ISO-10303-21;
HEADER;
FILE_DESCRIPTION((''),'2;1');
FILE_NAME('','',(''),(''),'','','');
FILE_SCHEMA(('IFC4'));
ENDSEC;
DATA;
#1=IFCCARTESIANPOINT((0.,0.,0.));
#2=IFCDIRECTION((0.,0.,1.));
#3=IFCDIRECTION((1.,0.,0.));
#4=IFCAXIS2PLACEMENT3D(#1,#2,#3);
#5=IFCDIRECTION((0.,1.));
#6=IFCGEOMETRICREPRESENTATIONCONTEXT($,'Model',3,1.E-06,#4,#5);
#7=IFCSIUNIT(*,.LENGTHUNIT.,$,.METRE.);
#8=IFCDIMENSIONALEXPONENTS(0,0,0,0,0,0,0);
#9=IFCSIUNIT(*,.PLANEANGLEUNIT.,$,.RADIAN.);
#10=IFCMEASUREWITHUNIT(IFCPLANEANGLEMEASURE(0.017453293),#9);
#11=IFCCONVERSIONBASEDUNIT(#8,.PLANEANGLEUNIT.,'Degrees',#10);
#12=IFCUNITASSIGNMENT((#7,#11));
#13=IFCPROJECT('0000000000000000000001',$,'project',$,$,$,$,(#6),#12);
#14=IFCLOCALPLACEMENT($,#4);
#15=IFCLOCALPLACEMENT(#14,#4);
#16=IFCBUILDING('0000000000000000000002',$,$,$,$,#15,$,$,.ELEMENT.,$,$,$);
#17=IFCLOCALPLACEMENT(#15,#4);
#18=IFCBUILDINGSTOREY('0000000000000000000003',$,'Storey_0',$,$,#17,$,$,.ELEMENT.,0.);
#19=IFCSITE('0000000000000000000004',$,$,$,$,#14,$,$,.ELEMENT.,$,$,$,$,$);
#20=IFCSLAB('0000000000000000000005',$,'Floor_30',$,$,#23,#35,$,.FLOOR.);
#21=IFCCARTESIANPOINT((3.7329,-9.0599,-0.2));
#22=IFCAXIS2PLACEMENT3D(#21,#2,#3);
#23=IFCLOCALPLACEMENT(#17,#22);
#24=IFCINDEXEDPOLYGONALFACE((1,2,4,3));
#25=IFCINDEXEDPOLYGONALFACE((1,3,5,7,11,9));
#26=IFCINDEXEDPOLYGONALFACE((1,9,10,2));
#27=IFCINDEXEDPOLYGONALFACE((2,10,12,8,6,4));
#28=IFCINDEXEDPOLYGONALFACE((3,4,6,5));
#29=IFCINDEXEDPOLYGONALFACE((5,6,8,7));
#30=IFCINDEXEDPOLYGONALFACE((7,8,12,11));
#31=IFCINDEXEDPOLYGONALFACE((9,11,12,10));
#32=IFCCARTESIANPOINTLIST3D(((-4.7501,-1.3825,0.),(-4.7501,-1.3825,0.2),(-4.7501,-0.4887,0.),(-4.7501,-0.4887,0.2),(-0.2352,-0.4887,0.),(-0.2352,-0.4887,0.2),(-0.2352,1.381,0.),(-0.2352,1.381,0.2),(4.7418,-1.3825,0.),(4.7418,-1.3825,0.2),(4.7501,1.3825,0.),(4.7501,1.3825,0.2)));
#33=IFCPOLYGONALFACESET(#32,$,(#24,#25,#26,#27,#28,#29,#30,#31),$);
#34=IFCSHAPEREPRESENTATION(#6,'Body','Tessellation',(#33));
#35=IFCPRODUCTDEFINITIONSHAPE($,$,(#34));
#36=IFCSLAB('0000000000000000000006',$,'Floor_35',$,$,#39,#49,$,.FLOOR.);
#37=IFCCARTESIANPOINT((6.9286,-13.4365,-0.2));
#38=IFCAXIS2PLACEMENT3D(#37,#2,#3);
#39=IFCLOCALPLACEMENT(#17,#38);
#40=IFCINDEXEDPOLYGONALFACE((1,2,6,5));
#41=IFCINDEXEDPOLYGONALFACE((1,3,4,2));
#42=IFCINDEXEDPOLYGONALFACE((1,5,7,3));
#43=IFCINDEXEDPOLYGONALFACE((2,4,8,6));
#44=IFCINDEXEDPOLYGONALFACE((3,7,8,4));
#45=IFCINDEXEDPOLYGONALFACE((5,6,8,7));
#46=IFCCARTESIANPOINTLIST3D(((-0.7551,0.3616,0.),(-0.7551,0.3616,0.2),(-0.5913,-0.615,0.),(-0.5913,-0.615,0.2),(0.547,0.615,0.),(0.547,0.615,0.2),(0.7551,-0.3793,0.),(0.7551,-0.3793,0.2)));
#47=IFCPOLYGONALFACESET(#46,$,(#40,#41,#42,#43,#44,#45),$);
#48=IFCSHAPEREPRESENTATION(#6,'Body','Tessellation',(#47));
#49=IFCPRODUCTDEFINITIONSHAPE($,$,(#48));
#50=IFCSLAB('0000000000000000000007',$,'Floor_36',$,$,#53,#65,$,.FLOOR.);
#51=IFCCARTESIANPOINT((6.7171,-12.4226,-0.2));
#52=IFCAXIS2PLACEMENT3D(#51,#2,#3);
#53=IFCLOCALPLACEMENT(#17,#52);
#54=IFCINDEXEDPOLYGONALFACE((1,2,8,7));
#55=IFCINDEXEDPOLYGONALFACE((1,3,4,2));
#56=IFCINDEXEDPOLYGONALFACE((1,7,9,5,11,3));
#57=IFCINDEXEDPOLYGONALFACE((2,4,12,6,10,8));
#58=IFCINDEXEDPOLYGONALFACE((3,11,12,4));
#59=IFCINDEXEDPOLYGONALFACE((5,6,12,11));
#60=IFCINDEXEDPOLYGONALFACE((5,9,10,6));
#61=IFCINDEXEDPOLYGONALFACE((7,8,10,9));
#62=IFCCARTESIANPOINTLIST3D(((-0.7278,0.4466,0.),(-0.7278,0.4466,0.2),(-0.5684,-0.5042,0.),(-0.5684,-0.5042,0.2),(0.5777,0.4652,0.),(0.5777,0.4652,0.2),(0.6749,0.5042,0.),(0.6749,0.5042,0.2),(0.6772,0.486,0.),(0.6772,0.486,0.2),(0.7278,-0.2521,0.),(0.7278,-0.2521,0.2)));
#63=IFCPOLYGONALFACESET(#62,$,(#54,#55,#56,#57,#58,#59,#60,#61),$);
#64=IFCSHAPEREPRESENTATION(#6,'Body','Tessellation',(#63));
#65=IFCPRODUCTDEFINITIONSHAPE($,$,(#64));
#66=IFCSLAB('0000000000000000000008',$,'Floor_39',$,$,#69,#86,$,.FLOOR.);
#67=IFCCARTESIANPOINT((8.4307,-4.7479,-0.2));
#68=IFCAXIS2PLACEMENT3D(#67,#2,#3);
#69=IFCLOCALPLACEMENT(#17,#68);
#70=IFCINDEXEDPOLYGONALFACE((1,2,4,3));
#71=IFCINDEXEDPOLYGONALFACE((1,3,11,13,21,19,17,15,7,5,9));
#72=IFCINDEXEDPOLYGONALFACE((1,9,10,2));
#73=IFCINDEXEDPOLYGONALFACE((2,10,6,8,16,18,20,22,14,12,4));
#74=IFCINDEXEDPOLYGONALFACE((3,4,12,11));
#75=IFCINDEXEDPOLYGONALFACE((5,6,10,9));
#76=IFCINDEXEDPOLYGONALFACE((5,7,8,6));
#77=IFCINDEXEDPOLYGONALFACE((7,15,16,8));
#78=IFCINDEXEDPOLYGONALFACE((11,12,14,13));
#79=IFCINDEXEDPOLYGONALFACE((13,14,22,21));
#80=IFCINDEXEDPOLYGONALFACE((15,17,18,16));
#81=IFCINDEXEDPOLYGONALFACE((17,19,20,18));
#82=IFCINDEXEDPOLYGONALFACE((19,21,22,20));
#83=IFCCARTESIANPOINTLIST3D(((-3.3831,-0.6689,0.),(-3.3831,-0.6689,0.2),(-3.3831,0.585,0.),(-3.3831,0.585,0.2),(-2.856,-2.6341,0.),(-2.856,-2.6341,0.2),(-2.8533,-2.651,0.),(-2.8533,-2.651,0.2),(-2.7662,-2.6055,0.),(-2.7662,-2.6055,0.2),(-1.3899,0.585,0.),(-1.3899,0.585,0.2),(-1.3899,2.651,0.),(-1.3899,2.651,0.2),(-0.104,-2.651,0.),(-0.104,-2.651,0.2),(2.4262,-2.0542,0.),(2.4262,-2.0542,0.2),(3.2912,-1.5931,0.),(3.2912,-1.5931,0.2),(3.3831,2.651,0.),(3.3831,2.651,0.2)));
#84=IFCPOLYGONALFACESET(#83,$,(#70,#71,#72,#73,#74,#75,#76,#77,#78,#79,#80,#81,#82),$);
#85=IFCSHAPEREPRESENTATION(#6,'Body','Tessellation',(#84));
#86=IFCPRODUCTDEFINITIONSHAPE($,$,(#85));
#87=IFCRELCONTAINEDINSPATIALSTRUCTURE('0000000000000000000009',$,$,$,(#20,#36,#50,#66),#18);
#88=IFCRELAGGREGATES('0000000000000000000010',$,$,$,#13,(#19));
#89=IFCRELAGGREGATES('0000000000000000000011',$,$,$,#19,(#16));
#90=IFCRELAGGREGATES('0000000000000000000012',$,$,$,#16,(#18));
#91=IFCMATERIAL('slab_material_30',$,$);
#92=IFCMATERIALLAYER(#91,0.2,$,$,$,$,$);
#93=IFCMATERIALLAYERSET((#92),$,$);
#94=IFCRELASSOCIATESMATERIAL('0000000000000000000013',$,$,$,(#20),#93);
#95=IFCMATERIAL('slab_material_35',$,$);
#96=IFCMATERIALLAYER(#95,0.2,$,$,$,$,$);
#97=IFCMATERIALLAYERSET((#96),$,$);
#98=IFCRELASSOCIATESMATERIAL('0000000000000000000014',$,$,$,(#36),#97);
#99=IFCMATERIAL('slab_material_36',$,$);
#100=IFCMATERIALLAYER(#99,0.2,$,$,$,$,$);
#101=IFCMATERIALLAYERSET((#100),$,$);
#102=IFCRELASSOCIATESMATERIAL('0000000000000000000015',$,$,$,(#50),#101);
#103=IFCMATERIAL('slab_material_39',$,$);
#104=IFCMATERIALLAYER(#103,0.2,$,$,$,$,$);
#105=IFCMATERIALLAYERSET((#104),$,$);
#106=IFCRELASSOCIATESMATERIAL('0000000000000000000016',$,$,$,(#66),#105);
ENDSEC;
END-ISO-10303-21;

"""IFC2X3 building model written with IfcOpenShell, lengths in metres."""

from ifc_helpers import new_model, entity, si_unit, converted_unit, direction, frame, origin_with_axes, place, context, project, spatial, polyline, outline, extrude, material, layer, layer_set, layer_usage, element, save


model = new_model("IFC2X3")

# Units and contexts
model_context = context("Model", 3, precision=1e-06, world=origin_with_axes(), true_north=direction((0.0, 1.0)))
ifc_project = project(units=[si_unit("LENGTHUNIT", "METRE"), converted_unit("PLANEANGLEUNIT", "Degrees", entity("IfcPlaneAngleMeasure", 0.017453293), si_unit("PLANEANGLEUNIT", "RADIAN"), dimensions=[0, 0, 0, 0, 0, 0, 0])], contexts=[model_context])

# Site, building, storey
site_placement = place(None, origin_with_axes())
site = spatial("IfcSite", under=ifc_project, at=site_placement, CompositionType="ELEMENT")
building_placement = place(site_placement, origin_with_axes())
building = spatial("IfcBuilding", under=site, at=building_placement, CompositionType="ELEMENT")
storey_placement = place(building_placement, origin_with_axes())
storey = spatial("IfcBuildingStorey", under=building, at=storey_placement, Name="Storey_0", CompositionType="ELEMENT", Elevation=0.0)

# Slabs
ifc_material_1 = material(Name="slab_material_30")
ifc_layer_1 = layer(ifc_material_1, 0.2)
ifc_layer_set_1 = layer_set([ifc_layer_1])
ifc_layer_usage_1 = layer_usage(ifc_layer_set_1, "AXIS3", "POSITIVE", 0.0)
slab_1_placement = place(storey_placement, frame((3.7329, -9.0599, -0.2), z_axis=(0.0, 0.0, 1.0), x_axis=(1.0, 0.0, 0.0)))
element("IfcSlab", 1, at=slab_1_placement, inside=storey, material=ifc_layer_usage_1, Name="Floor_30", PredefinedType="FLOOR", context=model_context, shape_type="SweptSolid", body=[
    extrude(outline(polyline([(4.7501, 1.3825), (4.7418, -1.3825), (-4.7501, -1.3825), (-4.7501, -0.4887), (-0.2352, -0.4887), (-0.2352, 1.381), (4.7501, 1.3825)])), origin_with_axes(), (0.0, 0.0, 1.0), 0.2),
])
ifc_material_2 = material(Name="slab_material_35")
ifc_layer_2 = layer(ifc_material_2, 0.2)
ifc_layer_set_2 = layer_set([ifc_layer_2])
ifc_layer_usage_2 = layer_usage(ifc_layer_set_2, "AXIS3", "POSITIVE", 0.0)
slab_2_placement = place(storey_placement, frame((6.9286, -13.4365, -0.2), z_axis=(0.0, 0.0, 1.0), x_axis=(1.0, 0.0, 0.0)))
element("IfcSlab", 2, at=slab_2_placement, inside=storey, material=ifc_layer_usage_2, Name="Floor_35", PredefinedType="FLOOR", context=model_context, shape_type="SweptSolid", body=[
    extrude(outline(polyline([(0.7551, -0.3793), (-0.5913, -0.615), (-0.7551, 0.3616), (0.547, 0.615), (0.7551, -0.3793)])), origin_with_axes(), (0.0, 0.0, 1.0), 0.2),
])
ifc_material_3 = material(Name="slab_material_36")
ifc_layer_3 = layer(ifc_material_3, 0.2)
ifc_layer_set_3 = layer_set([ifc_layer_3])
ifc_layer_usage_3 = layer_usage(ifc_layer_set_3, "AXIS3", "POSITIVE", 0.0)
slab_3_placement = place(storey_placement, frame((6.7171, -12.4226, -0.2), z_axis=(0.0, 0.0, 1.0), x_axis=(1.0, 0.0, 0.0)))
element("IfcSlab", 3, at=slab_3_placement, inside=storey, material=ifc_layer_usage_3, Name="Floor_36", PredefinedType="FLOOR", context=model_context, shape_type="SweptSolid", body=[
    extrude(outline(polyline([(0.6772, 0.486), (0.5777, 0.4652), (0.7278, -0.2521), (-0.5684, -0.5042), (-0.7278, 0.4466), (0.6749, 0.5042), (0.6772, 0.486)])), origin_with_axes(), (0.0, 0.0, 1.0), 0.2),
])
ifc_material_4 = material(Name="slab_material_39")
ifc_layer_4 = layer(ifc_material_4, 0.2)
ifc_layer_set_4 = layer_set([ifc_layer_4])
ifc_layer_usage_4 = layer_usage(ifc_layer_set_4, "AXIS3", "POSITIVE", 0.0)
slab_4_placement = place(storey_placement, frame((8.4307, -4.7479, -0.2), z_axis=(0.0, 0.0, 1.0), x_axis=(1.0, 0.0, 0.0)))
element("IfcSlab", 4, at=slab_4_placement, inside=storey, material=ifc_layer_usage_4, Name="Floor_39", PredefinedType="FLOOR", context=model_context, shape_type="SweptSolid", body=[
    extrude(outline(polyline([(3.2912, -1.5931), (2.4262, -2.0542), (-0.104, -2.651), (-2.8533, -2.651), (-2.856, -2.6341), (-2.7662, -2.6055), (-3.3831, -0.6689), (-3.3831, 0.585), (-1.3899, 0.585), (-1.3899, 2.651), (3.3831, 2.651), (3.2912, -1.5931)])), origin_with_axes(), (0.0, 0.0, 1.0), 0.2),
])

save(model, "model.ifc")
